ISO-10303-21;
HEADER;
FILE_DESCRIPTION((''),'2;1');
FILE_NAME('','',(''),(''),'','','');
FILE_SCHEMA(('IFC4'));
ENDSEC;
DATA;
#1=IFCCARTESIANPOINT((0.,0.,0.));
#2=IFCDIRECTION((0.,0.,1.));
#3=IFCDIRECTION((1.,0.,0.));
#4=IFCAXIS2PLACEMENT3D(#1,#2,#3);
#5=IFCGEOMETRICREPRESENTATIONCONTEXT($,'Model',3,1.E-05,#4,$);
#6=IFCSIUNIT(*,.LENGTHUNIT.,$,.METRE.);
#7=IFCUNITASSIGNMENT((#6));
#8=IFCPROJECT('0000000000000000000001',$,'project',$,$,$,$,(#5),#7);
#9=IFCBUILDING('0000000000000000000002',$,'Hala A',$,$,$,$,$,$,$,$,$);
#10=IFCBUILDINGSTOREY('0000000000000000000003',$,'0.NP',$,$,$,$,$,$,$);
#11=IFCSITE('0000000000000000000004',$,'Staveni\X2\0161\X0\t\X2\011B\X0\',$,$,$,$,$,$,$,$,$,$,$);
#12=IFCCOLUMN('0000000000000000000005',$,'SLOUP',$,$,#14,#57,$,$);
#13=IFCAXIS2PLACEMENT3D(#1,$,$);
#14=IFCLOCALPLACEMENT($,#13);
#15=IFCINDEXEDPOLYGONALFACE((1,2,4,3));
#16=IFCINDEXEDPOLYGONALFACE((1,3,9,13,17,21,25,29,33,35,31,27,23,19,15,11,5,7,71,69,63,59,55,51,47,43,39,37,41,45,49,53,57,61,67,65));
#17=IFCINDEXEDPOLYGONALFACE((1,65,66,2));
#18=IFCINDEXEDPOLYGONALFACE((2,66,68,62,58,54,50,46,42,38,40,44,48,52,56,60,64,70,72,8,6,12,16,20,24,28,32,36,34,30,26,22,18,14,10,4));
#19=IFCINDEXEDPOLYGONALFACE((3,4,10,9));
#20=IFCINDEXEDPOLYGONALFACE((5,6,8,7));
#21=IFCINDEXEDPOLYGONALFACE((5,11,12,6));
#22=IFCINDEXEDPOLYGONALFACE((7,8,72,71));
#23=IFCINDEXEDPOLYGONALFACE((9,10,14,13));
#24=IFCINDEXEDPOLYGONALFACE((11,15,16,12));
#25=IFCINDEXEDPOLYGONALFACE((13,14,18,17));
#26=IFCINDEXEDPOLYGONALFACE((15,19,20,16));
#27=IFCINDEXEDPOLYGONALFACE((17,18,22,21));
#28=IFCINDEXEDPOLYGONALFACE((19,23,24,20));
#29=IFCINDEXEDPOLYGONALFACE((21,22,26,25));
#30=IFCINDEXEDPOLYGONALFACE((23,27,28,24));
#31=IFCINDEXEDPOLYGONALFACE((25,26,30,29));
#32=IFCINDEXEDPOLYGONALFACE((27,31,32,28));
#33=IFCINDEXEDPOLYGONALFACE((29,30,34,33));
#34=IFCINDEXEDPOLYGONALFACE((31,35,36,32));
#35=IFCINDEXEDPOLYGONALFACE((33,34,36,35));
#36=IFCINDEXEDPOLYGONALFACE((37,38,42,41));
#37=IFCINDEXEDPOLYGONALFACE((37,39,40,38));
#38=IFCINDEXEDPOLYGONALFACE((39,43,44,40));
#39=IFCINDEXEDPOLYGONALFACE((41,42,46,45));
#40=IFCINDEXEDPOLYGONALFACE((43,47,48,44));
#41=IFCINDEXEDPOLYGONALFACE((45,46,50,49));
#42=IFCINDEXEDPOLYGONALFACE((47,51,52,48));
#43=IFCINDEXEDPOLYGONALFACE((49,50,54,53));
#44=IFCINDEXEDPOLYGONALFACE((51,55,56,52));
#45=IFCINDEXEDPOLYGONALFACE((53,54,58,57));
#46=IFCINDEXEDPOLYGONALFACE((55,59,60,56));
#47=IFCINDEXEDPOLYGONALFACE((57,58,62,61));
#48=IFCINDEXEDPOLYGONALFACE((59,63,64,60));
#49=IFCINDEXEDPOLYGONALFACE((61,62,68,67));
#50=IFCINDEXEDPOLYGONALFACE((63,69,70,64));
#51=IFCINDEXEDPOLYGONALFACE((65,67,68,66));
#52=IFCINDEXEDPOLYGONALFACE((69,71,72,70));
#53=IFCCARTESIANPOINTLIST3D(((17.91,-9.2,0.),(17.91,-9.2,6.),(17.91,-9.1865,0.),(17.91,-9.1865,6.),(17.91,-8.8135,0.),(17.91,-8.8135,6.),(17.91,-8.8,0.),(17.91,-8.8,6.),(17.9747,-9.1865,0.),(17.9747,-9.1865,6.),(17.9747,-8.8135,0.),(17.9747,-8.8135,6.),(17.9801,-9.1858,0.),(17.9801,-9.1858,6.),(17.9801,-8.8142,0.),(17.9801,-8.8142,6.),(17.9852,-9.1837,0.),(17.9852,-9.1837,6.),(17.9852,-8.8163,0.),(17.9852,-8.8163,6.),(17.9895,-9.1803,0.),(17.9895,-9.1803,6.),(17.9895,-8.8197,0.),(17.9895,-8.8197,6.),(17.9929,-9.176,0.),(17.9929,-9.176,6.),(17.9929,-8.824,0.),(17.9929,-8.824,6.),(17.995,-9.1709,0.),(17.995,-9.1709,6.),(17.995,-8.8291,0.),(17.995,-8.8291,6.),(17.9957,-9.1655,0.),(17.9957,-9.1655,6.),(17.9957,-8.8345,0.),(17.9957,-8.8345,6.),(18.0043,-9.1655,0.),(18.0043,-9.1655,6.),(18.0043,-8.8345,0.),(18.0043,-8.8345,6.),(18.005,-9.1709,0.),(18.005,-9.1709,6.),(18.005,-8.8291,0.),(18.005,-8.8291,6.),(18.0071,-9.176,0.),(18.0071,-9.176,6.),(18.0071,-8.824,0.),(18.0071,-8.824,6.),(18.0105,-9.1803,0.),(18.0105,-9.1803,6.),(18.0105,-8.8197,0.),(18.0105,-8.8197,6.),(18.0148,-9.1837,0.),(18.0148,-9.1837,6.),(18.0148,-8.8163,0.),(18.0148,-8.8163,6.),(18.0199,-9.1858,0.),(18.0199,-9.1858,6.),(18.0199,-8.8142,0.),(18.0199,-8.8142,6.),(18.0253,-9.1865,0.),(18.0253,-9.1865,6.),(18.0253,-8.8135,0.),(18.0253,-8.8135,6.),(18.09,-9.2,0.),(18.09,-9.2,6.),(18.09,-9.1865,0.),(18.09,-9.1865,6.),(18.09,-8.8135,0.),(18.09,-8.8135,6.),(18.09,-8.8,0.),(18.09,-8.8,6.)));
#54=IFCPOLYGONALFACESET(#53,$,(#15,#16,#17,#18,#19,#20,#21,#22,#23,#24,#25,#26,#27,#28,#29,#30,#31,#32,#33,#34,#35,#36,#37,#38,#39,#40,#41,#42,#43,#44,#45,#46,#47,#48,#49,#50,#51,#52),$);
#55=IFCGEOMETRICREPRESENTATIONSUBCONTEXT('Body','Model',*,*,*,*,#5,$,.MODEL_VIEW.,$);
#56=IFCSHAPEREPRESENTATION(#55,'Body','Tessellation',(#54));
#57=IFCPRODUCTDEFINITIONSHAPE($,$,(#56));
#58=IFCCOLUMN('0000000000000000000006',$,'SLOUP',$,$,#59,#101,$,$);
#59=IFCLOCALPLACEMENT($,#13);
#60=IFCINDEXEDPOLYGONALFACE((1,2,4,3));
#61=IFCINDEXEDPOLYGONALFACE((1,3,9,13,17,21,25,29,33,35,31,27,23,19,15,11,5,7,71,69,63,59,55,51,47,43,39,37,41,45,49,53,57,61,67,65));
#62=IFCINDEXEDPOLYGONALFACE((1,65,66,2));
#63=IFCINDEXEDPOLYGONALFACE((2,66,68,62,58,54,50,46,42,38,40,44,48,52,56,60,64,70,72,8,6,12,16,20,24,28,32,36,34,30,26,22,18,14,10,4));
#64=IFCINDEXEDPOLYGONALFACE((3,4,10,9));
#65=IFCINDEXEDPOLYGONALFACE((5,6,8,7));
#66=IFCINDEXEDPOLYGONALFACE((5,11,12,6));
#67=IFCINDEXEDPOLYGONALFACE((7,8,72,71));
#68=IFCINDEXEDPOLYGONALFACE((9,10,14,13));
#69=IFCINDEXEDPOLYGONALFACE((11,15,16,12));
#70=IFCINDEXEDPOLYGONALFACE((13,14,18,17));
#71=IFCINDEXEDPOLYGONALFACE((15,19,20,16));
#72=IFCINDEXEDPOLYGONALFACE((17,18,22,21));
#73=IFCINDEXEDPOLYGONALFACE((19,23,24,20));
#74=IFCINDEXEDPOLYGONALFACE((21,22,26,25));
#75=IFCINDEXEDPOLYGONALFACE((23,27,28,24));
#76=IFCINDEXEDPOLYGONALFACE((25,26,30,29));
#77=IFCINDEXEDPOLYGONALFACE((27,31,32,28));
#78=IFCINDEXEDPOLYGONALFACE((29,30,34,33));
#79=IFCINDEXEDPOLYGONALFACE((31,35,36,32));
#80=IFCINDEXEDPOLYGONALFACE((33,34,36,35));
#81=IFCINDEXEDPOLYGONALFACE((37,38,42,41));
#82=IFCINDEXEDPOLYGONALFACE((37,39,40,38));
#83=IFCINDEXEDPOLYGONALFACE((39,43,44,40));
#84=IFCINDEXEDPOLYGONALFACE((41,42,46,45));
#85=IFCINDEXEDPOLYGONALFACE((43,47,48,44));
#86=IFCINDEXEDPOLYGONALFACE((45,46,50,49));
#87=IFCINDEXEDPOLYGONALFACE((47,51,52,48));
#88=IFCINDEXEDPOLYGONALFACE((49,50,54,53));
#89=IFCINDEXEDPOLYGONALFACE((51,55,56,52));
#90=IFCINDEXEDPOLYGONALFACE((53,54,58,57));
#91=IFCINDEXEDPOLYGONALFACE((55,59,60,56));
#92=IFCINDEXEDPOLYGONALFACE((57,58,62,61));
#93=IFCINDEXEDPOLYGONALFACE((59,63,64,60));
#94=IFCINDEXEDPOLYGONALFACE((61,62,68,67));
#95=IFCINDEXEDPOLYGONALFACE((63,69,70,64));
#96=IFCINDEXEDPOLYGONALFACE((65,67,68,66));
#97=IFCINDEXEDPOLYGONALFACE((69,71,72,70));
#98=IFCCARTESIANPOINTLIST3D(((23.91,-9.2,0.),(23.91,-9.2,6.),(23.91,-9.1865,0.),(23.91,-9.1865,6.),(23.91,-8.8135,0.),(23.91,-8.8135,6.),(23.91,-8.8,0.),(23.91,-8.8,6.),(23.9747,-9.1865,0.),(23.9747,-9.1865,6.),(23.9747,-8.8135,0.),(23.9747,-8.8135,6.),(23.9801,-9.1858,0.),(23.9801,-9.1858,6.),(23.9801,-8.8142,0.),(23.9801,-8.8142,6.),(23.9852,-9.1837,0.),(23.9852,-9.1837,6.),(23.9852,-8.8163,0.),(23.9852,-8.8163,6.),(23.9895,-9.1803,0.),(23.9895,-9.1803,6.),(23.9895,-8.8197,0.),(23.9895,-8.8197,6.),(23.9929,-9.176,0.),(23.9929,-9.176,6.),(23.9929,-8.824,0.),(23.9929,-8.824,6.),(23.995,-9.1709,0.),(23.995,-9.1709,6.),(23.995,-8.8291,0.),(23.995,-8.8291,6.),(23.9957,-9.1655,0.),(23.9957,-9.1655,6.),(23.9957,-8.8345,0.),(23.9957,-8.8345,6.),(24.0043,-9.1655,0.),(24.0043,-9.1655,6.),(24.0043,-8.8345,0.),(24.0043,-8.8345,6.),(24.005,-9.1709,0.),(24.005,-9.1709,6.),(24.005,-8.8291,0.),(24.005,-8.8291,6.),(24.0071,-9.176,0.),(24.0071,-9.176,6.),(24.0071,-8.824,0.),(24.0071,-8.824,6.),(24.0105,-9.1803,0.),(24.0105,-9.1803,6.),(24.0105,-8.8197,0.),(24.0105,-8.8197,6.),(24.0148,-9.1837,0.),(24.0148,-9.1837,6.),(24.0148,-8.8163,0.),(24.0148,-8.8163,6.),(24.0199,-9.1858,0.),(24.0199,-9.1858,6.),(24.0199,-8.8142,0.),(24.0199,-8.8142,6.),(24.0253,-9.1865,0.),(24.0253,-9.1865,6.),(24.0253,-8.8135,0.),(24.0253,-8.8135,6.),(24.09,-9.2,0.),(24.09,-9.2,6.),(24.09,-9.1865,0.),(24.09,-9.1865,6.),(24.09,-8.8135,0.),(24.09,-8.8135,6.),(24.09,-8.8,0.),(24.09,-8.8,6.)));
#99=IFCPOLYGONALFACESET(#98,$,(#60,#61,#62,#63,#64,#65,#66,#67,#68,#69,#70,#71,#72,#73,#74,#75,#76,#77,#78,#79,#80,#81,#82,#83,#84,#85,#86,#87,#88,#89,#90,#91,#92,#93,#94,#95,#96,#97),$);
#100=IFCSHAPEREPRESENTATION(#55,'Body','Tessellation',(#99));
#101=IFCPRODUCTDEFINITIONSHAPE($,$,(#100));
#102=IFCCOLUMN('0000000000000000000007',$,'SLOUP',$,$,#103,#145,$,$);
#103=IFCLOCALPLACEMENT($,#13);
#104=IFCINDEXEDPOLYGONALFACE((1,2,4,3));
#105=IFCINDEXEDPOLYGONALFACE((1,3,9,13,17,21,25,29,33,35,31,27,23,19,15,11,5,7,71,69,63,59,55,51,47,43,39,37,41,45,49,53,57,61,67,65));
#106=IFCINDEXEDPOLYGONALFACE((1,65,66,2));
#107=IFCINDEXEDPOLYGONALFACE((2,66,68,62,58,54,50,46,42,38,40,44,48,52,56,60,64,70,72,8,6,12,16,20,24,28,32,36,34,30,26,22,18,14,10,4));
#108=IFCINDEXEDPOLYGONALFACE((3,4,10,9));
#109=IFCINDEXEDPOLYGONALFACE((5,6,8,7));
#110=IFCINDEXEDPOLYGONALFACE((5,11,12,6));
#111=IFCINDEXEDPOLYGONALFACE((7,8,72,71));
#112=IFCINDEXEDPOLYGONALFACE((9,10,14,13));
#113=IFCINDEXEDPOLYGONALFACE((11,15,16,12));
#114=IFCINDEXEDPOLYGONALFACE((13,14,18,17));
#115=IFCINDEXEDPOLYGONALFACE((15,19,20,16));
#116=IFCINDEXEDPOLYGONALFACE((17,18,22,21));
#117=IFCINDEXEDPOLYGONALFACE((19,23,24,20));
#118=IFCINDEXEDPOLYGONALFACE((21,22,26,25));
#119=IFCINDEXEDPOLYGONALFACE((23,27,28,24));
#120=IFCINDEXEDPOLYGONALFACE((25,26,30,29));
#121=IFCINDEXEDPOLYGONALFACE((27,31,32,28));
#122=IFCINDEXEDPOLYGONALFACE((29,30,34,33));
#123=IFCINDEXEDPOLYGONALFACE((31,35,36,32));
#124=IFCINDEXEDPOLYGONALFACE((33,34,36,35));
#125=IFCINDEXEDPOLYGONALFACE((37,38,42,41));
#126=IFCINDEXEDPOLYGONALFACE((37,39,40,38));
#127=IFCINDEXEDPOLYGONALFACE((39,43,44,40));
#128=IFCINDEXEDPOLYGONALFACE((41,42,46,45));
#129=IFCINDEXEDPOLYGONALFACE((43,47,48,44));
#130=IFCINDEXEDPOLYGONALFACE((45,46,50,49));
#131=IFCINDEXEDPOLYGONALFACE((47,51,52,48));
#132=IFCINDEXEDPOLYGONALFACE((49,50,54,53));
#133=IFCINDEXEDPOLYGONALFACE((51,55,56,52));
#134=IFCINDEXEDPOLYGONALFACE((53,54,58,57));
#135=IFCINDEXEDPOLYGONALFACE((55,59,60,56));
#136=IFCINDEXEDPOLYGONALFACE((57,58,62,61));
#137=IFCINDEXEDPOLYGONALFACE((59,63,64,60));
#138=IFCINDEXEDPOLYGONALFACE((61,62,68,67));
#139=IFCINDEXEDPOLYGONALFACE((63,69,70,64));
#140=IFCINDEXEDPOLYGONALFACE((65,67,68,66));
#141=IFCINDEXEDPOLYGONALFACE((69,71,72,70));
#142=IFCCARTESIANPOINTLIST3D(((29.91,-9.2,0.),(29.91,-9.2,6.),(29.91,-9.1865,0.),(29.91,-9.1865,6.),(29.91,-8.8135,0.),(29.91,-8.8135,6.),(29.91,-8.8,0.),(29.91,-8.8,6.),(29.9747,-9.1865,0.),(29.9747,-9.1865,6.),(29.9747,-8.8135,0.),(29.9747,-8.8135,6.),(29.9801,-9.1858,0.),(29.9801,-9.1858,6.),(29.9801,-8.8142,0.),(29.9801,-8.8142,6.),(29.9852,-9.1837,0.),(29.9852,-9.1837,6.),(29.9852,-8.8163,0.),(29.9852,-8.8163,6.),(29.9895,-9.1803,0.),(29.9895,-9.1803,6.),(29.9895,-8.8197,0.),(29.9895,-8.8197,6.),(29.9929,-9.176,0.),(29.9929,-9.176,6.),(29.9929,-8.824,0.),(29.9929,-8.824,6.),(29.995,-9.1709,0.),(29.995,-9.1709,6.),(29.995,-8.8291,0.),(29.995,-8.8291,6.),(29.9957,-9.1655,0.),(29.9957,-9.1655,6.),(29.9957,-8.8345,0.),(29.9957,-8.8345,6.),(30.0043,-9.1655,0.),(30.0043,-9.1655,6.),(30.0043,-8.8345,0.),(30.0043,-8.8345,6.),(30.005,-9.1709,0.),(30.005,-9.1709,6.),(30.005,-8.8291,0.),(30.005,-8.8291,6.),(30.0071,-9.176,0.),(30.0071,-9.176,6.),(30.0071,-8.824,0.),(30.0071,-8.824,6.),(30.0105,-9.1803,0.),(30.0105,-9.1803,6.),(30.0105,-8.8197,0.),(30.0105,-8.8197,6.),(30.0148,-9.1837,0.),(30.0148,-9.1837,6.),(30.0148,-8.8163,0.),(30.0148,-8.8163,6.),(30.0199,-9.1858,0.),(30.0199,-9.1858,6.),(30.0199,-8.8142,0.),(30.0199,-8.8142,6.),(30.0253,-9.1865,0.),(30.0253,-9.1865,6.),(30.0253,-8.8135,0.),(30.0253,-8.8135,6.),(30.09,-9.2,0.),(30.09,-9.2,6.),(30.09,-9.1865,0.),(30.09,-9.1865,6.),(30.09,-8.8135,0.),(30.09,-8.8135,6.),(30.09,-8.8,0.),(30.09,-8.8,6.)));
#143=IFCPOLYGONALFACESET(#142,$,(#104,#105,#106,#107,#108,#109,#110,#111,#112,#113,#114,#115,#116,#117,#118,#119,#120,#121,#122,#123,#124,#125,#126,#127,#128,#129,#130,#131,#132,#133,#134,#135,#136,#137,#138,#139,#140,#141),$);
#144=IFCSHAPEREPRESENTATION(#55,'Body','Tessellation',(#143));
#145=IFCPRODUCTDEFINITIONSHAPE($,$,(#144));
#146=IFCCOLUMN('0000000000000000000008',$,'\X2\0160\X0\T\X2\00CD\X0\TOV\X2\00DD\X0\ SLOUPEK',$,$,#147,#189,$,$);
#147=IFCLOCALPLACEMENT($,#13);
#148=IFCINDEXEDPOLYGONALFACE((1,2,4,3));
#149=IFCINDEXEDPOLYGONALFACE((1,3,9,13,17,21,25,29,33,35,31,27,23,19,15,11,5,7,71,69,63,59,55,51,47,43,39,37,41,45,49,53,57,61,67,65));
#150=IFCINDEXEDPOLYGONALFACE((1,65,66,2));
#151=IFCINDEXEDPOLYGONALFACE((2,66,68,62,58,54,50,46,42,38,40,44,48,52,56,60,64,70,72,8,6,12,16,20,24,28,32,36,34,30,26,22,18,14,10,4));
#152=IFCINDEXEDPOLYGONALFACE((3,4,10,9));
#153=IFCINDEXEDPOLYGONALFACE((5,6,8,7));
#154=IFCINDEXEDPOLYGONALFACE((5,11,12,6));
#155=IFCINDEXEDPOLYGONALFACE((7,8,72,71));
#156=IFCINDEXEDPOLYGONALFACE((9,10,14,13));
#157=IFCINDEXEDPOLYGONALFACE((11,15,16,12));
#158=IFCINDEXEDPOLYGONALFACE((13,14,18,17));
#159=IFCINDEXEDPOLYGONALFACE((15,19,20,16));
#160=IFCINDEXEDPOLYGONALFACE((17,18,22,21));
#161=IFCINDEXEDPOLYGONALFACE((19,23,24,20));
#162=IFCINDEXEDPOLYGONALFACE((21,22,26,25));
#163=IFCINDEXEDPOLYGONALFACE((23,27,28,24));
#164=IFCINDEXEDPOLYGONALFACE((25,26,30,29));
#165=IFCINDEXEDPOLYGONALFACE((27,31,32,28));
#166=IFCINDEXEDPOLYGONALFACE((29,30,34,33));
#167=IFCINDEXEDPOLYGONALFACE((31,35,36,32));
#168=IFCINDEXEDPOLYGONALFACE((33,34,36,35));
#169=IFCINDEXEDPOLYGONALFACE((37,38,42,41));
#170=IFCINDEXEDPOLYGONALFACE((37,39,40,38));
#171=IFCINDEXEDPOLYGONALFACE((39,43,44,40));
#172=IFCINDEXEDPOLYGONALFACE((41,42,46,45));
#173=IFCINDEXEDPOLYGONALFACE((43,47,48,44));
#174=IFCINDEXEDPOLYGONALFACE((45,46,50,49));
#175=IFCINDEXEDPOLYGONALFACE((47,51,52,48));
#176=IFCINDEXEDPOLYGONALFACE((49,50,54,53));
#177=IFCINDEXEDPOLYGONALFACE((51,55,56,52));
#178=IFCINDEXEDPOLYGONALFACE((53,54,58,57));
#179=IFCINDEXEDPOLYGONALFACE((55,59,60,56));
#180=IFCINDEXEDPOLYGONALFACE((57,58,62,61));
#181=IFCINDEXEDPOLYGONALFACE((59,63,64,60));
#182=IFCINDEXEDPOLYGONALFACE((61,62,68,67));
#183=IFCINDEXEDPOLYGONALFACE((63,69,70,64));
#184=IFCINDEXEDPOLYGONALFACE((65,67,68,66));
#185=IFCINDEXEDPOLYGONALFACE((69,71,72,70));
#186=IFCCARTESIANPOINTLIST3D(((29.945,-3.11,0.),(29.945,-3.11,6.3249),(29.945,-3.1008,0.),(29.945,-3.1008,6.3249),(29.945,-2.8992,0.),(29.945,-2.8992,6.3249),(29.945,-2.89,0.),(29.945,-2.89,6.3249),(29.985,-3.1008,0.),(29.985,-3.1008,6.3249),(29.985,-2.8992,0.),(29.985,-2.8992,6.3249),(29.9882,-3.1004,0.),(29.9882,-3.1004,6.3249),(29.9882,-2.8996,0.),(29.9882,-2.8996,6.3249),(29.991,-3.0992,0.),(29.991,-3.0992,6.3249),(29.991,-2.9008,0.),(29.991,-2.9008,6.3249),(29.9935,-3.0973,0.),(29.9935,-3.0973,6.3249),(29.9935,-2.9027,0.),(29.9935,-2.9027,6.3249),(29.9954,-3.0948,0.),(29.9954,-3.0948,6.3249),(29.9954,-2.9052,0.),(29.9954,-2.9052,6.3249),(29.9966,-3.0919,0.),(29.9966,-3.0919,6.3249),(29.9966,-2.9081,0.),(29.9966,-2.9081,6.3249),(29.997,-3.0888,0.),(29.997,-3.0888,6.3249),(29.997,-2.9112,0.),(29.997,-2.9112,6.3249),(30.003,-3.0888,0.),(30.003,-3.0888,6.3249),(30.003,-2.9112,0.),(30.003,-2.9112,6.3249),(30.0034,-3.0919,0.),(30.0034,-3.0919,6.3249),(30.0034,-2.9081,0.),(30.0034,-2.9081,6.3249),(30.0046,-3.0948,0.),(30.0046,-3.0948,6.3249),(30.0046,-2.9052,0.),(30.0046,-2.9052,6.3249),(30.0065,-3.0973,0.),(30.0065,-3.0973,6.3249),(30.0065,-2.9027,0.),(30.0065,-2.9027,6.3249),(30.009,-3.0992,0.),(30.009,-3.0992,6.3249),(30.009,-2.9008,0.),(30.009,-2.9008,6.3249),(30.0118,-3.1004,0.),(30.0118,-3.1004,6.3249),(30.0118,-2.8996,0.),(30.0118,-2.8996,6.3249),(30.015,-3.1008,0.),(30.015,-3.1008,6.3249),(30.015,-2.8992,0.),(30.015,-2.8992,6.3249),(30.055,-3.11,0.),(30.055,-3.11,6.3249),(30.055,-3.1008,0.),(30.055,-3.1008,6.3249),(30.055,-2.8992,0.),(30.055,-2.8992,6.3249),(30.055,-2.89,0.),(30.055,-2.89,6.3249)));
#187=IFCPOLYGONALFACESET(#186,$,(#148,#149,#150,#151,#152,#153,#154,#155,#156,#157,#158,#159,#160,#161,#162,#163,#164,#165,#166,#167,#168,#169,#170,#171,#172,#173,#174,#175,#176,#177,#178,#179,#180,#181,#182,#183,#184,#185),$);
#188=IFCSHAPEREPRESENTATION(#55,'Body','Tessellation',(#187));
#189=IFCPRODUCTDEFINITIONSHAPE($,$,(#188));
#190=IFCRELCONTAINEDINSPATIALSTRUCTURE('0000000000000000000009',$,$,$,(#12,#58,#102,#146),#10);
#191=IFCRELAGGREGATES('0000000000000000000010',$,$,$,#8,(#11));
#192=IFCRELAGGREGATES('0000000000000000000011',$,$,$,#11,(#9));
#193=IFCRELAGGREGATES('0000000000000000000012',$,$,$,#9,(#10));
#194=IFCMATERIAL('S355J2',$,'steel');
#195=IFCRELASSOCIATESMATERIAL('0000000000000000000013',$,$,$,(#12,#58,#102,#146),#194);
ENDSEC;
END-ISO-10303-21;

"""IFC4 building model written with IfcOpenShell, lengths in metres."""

from ifc_helpers import new_model, si_unit, frame, origin_with_axes, place, context, subcontext, project, spatial, i_section, extrude, material, element, save


model = new_model("IFC4")

# Units and contexts
model_context = context("Model", 3, precision=1e-05, world=origin_with_axes())
body_context = subcontext(model_context, "Body", "Model", "MODEL_VIEW")
ifc_project = project(units=[si_unit("LENGTHUNIT", "METRE")], contexts=[model_context])

# Site, building, storey
site = spatial("IfcSite", under=ifc_project, Name="Staveniště")
building = spatial("IfcBuilding", under=site, Name="Hala A")
storey = spatial("IfcBuildingStorey", under=building, Name="0.NP")

# Columns
ifc_material = material(Name="S355J2", Category="steel")
for number, where, z_axis, x_axis, name in (
    (1, (18.0, -9.0, 0.0), (0.0, 0.0, 1.0), (1.0, 0.0, 0.0), "SLOUP"),
    (2, (24.0, -9.0, 0.0), (0.0, 0.0, 1.0), (1.0, 0.0, 0.0), "SLOUP"),
    (3, (30.0, -9.0, 0.0), (0.0, 0.0, 1.0), (1.0, 0.0, 0.0), "SLOUP"),
):
    element("IfcColumn", number, at=place(None, frame(where, z_axis=z_axis, x_axis=x_axis)), inside=storey, material=ifc_material, Name=name, context=body_context, shape_type="SweptSolid", body=[
        extrude(i_section(OverallWidth=0.18, OverallDepth=0.4, WebThickness=0.0086, FlangeThickness=0.0135, FilletRadius=0.021), origin_with_axes(), (0.0, 0.0, 1.0), 6.0),
    ])
column_placement = place(None, frame((30.0, -3.0, 0.0), z_axis=(0.0, 0.0, 1.0), x_axis=(1.0, 0.0, 0.0)))
element("IfcColumn", 4, at=column_placement, inside=storey, material=ifc_material, Name="ŠTÍTOVÝ SLOUPEK", context=body_context, shape_type="SweptSolid", body=[
    extrude(i_section(OverallWidth=0.11, OverallDepth=0.22, WebThickness=0.0059, FlangeThickness=0.0092, FilletRadius=0.012), origin_with_axes(), (0.0, 0.0, 1.0), 6.3249),
])

save(model, "model.ifc")
